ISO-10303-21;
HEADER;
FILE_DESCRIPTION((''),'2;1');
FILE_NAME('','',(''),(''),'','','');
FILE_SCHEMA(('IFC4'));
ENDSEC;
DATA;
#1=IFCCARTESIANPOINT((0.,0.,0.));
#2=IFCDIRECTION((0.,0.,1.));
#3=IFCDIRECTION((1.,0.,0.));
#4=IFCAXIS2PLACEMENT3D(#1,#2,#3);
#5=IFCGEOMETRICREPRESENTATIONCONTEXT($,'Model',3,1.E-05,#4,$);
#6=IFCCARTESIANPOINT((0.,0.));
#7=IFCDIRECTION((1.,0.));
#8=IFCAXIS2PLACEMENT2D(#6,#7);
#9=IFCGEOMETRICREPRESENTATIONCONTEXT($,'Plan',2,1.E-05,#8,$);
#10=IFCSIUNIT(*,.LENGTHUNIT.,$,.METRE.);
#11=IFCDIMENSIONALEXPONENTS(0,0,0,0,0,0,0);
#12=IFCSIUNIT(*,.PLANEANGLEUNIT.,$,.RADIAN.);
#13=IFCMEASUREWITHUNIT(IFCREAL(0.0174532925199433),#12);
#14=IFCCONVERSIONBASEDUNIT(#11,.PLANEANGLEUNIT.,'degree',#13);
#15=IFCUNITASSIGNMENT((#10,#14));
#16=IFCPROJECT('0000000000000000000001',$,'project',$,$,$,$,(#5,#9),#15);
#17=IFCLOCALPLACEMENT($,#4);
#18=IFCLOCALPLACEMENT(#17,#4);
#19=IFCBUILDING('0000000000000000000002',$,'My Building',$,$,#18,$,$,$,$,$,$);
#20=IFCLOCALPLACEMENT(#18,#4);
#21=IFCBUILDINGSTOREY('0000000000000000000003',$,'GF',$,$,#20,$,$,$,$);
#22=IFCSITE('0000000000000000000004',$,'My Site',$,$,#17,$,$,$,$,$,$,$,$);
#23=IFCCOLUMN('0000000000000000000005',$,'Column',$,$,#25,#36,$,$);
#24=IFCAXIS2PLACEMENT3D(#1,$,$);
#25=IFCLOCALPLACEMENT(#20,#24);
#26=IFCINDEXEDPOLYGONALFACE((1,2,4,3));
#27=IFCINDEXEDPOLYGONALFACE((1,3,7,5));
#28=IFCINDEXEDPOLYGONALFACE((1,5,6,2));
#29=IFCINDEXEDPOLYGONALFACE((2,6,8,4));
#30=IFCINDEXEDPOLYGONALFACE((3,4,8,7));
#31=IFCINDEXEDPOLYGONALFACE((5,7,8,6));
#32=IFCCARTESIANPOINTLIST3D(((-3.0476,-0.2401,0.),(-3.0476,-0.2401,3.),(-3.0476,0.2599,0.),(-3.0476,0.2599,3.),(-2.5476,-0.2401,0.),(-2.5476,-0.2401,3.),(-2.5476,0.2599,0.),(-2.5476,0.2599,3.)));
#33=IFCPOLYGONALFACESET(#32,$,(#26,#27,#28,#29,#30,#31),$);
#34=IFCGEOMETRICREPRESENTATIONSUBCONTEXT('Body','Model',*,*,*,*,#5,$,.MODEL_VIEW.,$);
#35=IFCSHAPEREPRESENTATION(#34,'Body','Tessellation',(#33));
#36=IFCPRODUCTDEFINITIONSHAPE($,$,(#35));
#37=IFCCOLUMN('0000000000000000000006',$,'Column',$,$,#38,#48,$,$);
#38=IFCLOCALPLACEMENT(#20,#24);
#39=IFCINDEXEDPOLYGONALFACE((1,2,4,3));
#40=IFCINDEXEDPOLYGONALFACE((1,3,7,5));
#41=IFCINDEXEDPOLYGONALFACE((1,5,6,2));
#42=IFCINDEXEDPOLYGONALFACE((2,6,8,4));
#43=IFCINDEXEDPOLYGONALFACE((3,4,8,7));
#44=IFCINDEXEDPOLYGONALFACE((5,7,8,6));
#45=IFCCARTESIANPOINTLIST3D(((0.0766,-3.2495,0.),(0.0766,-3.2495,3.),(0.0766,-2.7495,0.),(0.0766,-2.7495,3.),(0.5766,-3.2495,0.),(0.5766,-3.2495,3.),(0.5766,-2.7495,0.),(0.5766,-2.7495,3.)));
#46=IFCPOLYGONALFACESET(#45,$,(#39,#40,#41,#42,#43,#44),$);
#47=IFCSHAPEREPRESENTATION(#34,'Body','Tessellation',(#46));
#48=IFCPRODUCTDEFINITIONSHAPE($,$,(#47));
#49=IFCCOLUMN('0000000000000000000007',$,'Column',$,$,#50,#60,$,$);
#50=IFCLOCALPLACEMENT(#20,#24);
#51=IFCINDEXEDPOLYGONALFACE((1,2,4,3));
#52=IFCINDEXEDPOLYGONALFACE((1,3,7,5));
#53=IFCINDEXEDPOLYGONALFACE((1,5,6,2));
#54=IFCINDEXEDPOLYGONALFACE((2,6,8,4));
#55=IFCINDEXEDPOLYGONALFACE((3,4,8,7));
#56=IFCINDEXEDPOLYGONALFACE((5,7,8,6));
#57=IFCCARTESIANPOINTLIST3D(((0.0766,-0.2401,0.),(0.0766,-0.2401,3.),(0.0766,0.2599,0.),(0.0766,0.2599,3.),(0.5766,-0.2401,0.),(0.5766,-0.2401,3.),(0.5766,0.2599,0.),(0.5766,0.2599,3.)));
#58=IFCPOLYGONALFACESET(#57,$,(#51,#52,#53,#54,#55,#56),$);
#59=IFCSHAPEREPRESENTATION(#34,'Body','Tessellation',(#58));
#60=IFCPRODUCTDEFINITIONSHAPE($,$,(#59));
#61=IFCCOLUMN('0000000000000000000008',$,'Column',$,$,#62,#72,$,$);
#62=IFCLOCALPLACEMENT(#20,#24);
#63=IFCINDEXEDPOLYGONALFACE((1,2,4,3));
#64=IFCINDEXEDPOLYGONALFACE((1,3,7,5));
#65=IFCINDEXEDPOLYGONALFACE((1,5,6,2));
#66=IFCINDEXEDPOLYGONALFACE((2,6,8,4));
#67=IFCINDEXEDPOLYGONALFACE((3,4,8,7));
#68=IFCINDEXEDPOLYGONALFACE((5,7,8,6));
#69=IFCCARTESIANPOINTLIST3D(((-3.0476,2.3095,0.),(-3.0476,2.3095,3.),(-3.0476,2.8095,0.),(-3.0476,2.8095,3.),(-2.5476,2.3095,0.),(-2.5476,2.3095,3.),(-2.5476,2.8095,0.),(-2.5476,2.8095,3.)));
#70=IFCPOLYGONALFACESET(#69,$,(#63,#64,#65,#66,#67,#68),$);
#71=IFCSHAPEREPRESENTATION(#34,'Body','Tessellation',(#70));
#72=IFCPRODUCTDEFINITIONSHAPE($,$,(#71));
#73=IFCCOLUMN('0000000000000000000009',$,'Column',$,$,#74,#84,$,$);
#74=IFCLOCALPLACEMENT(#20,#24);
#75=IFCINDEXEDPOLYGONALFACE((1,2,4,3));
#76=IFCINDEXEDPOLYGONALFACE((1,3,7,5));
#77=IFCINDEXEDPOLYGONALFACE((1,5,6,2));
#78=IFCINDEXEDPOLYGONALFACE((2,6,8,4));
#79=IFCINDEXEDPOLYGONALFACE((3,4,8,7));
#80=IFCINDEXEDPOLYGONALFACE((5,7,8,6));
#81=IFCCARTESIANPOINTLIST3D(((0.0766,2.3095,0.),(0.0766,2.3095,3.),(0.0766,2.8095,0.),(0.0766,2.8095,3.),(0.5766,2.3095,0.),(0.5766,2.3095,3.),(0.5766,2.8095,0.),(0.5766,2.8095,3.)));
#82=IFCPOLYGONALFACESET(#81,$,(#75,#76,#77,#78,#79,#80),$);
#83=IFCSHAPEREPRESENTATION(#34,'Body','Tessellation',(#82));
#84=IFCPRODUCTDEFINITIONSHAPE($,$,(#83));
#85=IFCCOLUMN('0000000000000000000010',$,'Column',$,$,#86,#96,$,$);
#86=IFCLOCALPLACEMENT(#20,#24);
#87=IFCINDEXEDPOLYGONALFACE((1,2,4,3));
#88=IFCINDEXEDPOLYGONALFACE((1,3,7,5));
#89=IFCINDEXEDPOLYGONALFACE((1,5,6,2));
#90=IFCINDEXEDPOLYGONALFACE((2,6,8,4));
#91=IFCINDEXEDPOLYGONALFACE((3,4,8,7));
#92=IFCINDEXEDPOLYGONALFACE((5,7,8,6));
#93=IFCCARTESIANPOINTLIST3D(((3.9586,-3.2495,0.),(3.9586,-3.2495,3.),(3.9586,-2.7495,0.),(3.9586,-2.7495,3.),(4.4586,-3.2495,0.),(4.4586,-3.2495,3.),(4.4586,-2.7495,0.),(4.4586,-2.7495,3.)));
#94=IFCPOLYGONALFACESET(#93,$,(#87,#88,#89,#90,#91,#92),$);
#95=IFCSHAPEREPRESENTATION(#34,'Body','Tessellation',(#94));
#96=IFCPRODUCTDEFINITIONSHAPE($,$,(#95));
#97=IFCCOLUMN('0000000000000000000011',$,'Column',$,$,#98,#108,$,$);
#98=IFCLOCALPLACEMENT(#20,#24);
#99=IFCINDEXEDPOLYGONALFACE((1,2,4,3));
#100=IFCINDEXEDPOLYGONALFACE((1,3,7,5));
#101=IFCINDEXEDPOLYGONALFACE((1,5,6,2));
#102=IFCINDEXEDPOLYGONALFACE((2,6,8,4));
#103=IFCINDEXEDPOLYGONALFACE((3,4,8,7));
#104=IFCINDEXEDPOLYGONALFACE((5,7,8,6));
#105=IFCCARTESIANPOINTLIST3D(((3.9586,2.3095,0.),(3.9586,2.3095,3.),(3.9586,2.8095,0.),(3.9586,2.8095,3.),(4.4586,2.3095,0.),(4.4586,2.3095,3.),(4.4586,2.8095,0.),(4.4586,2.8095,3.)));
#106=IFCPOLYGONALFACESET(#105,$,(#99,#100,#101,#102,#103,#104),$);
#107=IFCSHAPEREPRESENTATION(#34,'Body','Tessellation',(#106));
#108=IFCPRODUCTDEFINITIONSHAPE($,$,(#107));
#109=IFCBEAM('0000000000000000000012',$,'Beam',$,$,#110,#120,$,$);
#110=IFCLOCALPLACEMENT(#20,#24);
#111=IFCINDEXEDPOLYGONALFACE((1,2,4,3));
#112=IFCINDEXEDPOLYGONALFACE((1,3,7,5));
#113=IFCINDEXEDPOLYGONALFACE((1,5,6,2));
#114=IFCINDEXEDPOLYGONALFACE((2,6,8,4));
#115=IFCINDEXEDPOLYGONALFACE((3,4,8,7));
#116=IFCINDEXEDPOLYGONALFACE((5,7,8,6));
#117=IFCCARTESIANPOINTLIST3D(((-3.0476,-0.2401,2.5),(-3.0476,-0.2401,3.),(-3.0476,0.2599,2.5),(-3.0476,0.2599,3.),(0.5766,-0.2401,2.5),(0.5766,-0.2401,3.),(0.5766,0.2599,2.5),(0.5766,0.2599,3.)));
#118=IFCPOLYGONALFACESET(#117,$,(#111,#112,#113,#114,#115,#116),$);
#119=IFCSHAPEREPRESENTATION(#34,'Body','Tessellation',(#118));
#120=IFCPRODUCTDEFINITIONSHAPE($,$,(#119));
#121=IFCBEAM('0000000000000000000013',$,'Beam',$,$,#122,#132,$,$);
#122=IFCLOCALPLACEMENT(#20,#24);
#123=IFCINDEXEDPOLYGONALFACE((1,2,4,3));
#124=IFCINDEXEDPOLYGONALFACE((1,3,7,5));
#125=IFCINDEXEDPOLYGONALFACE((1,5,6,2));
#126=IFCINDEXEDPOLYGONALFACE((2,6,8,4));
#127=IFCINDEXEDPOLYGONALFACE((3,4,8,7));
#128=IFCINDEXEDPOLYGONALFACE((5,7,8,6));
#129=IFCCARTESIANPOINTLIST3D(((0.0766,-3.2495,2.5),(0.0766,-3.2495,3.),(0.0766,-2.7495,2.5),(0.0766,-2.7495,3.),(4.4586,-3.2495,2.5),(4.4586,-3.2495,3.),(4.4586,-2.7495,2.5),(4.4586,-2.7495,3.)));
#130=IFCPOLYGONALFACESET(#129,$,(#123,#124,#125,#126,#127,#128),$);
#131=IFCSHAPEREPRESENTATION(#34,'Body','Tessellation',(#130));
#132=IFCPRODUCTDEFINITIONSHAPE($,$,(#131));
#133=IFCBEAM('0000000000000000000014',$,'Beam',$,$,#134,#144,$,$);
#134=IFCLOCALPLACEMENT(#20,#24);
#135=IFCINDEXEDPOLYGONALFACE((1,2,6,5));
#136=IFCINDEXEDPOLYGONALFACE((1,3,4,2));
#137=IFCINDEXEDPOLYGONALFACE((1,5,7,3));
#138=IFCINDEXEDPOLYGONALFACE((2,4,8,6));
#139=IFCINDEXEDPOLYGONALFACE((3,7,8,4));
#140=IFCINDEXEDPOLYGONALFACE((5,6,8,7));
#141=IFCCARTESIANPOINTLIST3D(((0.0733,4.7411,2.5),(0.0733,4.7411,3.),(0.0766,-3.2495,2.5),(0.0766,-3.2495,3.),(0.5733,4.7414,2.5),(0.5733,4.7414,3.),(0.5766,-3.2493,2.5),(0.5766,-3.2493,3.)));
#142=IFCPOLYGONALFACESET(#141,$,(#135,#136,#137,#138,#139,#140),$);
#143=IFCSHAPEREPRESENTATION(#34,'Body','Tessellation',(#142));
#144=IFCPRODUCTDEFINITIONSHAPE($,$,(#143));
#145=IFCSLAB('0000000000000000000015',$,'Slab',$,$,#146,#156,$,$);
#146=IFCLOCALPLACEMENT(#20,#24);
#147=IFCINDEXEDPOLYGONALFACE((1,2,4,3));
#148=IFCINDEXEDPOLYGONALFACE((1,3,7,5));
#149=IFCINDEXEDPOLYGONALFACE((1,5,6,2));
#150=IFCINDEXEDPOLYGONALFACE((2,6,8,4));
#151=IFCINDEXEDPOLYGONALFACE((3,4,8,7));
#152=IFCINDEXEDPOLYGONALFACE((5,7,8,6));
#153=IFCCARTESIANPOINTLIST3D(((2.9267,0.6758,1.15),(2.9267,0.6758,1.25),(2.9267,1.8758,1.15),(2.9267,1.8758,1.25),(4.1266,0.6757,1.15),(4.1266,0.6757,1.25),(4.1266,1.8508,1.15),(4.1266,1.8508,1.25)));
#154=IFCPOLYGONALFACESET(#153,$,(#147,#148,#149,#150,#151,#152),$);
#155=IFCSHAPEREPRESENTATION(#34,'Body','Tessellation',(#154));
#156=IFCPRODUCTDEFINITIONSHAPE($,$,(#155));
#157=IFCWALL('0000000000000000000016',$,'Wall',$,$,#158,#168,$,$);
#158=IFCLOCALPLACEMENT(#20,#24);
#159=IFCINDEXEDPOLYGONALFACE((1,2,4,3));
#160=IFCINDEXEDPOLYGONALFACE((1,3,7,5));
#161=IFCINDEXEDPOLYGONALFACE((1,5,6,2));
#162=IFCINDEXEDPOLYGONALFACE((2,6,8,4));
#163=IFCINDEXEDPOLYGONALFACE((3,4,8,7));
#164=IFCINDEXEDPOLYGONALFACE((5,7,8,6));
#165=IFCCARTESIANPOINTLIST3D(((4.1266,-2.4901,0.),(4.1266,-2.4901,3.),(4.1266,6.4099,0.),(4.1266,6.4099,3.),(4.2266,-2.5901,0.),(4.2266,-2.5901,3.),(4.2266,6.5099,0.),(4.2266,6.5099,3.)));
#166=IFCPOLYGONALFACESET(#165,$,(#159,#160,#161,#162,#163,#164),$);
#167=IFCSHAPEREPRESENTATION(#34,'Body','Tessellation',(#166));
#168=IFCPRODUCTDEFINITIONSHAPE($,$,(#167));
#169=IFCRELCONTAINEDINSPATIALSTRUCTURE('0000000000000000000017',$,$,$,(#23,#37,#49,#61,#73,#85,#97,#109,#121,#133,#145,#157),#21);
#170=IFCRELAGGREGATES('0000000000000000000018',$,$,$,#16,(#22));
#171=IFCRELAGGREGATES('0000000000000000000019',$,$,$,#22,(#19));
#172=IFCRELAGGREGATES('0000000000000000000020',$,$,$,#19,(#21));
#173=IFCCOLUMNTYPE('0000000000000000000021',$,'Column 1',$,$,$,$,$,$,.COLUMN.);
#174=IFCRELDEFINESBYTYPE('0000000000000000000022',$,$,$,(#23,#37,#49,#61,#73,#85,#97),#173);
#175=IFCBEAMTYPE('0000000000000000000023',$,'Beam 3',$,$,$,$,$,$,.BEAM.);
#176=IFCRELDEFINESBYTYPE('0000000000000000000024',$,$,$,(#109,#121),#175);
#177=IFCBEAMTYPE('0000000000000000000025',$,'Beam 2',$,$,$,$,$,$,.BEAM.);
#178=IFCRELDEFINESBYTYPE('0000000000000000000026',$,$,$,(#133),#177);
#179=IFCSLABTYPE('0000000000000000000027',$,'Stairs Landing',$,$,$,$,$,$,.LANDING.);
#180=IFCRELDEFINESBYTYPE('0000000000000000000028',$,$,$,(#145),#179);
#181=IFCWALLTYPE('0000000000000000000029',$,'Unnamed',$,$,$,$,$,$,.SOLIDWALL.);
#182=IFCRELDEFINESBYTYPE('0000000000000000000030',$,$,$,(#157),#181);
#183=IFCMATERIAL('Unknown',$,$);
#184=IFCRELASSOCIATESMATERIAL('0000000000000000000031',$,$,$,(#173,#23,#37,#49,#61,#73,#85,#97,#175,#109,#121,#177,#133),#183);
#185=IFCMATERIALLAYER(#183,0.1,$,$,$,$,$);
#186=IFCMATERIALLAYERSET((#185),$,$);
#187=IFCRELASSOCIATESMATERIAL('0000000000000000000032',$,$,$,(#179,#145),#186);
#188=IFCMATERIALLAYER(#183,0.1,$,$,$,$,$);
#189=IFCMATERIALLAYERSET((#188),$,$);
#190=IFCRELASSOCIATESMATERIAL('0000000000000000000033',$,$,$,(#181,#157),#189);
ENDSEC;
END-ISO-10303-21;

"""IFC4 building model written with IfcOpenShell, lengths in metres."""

from ifc_helpers import new_model, entity, si_unit, converted_unit, frame, origin_with_axes, origin_2d_with_axis, place, context, subcontext, project, spatial, line, indexed_curve, outline, extrude, material, layer, layer_set, layer_usage, material_profile, profile_set, profile_usage, type_object, element, save


model = new_model("IFC4")

# Units and contexts
model_context = context("Model", 3, precision=1e-05, world=origin_with_axes())
plan_context = context("Plan", 2, precision=1e-05, world=origin_2d_with_axis())
body_context_1 = subcontext(model_context, "Body", "Model", "MODEL_VIEW")
ifc_project = project(units=[si_unit("LENGTHUNIT", "METRE"), converted_unit("PLANEANGLEUNIT", "degree", entity("IfcReal", 0.0174532925199433), si_unit("PLANEANGLEUNIT", "RADIAN"), dimensions=[0, 0, 0, 0, 0, 0, 0])], contexts=[model_context, plan_context])

# Site, building, storey
site_placement = place(None, origin_with_axes())
site = spatial("IfcSite", under=ifc_project, at=site_placement, Name="My Site")
building_placement = place(site_placement, origin_with_axes())
building = spatial("IfcBuilding", under=site, at=building_placement, Name="My Building")
storey_placement = place(building_placement, origin_with_axes())
storey = spatial("IfcBuildingStorey", under=building, at=storey_placement, Name="GF")

# Columns
ifc_material_1 = material(Name="Unknown")
ifc_material_profile_1 = material_profile(ifc_material_1, outline(indexed_curve([(-0.25, -0.25), (0.25, -0.25), (0.25, 0.25), (-0.25, 0.25), (-0.25, -0.25)])))
ifc_profile_set_1 = profile_set([ifc_material_profile_1])
ifc_profile_usage_1 = profile_usage(ifc_profile_set_1, cardinal=5)
column_type = type_object("IfcColumnType", Name="Column 1", PredefinedType="COLUMN", material=ifc_profile_set_1)
column_1_placement = place(storey_placement, frame((-2.7976, 0.0099, 0.0), z_axis=(0.0, 0.0, 1.0), x_axis=(1.0, 0.0, 0.0)))
element("IfcColumn", 1, at=column_1_placement, inside=storey, type_object=column_type, material=ifc_profile_usage_1, Name="Column", context=body_context_1, shape_type="SweptSolid", body=[
    extrude(outline(indexed_curve([(-0.25, -0.25), (0.25, -0.25), (0.25, 0.25), (-0.25, 0.25), (-0.25, -0.25)])), origin_with_axes(), (0.0, 0.0, 1.0), 3.0),
])
ifc_profile_usage_2 = profile_usage(ifc_profile_set_1, cardinal=5)
column_2_placement = place(storey_placement, frame((0.3266, -2.9995, 0.0), z_axis=(0.0, 0.0, 1.0), x_axis=(1.0, 0.0, 0.0)))
element("IfcColumn", 2, at=column_2_placement, inside=storey, type_object=column_type, material=ifc_profile_usage_2, Name="Column", context=body_context_1, shape_type="SweptSolid", body=[
    extrude(outline(indexed_curve([(-0.25, -0.25), (0.25, -0.25), (0.25, 0.25), (-0.25, 0.25), (-0.25, -0.25)])), origin_with_axes(), (0.0, 0.0, 1.0), 3.0),
])
ifc_profile_usage_3 = profile_usage(ifc_profile_set_1, cardinal=5)
column_3_placement = place(storey_placement, frame((0.3266, 0.0099, 0.0), z_axis=(0.0, 0.0, 1.0), x_axis=(1.0, 0.0, 0.0)))
element("IfcColumn", 3, at=column_3_placement, inside=storey, type_object=column_type, material=ifc_profile_usage_3, Name="Column", context=body_context_1, shape_type="SweptSolid", body=[
    extrude(outline(indexed_curve([(-0.25, -0.25), (0.25, -0.25), (0.25, 0.25), (-0.25, 0.25), (-0.25, -0.25)])), origin_with_axes(), (0.0, 0.0, 1.0), 3.0),
])
ifc_profile_usage_4 = profile_usage(ifc_profile_set_1, cardinal=5)
column_4_placement = place(storey_placement, frame((-2.7976, 2.5595, 0.0), z_axis=(0.0, 0.0, 1.0), x_axis=(1.0, 0.0, 0.0)))
element("IfcColumn", 4, at=column_4_placement, inside=storey, type_object=column_type, material=ifc_profile_usage_4, Name="Column", context=body_context_1, shape_type="SweptSolid", body=[
    extrude(outline(indexed_curve([(-0.25, -0.25), (0.25, -0.25), (0.25, 0.25), (-0.25, 0.25), (-0.25, -0.25)])), origin_with_axes(), (0.0, 0.0, 1.0), 3.0),
])
ifc_profile_usage_5 = profile_usage(ifc_profile_set_1, cardinal=5)
column_5_placement = place(storey_placement, frame((0.3266, 2.5595, 0.0), z_axis=(0.0, 0.0, 1.0), x_axis=(1.0, 0.0, 0.0)))
element("IfcColumn", 5, at=column_5_placement, inside=storey, type_object=column_type, material=ifc_profile_usage_5, Name="Column", context=body_context_1, shape_type="SweptSolid", body=[
    extrude(outline(indexed_curve([(-0.25, -0.25), (0.25, -0.25), (0.25, 0.25), (-0.25, 0.25), (-0.25, -0.25)])), origin_with_axes(), (0.0, 0.0, 1.0), 3.0),
])
ifc_profile_usage_6 = profile_usage(ifc_profile_set_1, cardinal=5)
column_6_placement = place(storey_placement, frame((4.2086, -2.9995, 0.0), z_axis=(0.0, 0.0, 1.0), x_axis=(1.0, 0.0, 0.0)))
element("IfcColumn", 6, at=column_6_placement, inside=storey, type_object=column_type, material=ifc_profile_usage_6, Name="Column", context=body_context_1, shape_type="SweptSolid", body=[
    extrude(outline(indexed_curve([(-0.25, -0.25), (0.25, -0.25), (0.25, 0.25), (-0.25, 0.25), (-0.25, -0.25)])), origin_with_axes(), (0.0, 0.0, 1.0), 3.0),
])
ifc_profile_usage_7 = profile_usage(ifc_profile_set_1, cardinal=5)
column_7_placement = place(storey_placement, frame((4.2086, 2.5595, 0.0), z_axis=(0.0, 0.0, 1.0), x_axis=(1.0, 0.0, 0.0)))
element("IfcColumn", 7, at=column_7_placement, inside=storey, type_object=column_type, material=ifc_profile_usage_7, Name="Column", context=body_context_1, shape_type="SweptSolid", body=[
    extrude(outline(indexed_curve([(-0.25, -0.25), (0.25, -0.25), (0.25, 0.25), (-0.25, 0.25), (-0.25, -0.25)])), origin_with_axes(), (0.0, 0.0, 1.0), 3.0),
])

# Beams
ifc_material_profile_2 = material_profile(ifc_material_1, outline(indexed_curve([(-0.25, -0.25), (0.25, -0.25), (0.25, 0.25), (-0.25, 0.25), (-0.25, -0.25)])))
ifc_profile_set_2 = profile_set([ifc_material_profile_2])
ifc_profile_usage_8 = profile_usage(ifc_profile_set_2, cardinal=7)
beam_type_1 = type_object("IfcBeamType", Name="Beam 3", PredefinedType="BEAM", material=ifc_profile_set_2)
beam_1_placement = place(storey_placement, frame((0.5766, -0.2401, 3.0), z_axis=(-1.0, 0.0, 0.0), x_axis=(0.0, -1.0, 0.0)))
element("IfcBeam", 8, at=beam_1_placement, inside=storey, type_object=beam_type_1, material=ifc_profile_usage_8, Name="Beam", context=body_context_1, shape_type="SweptSolid", body=[
    extrude(outline(indexed_curve([(-0.25, -0.25), (0.25, -0.25), (0.25, 0.25), (-0.25, 0.25), (-0.25, -0.25)])), frame((-0.25, -0.25, 0.0), z_axis=(0.0, 0.0, 1.0), x_axis=(1.0, 0.0, 0.0)), (0.0, 0.0, 1.0), 3.6242),
])
ifc_profile_usage_9 = profile_usage(ifc_profile_set_2, cardinal=7)
beam_2_placement = place(storey_placement, frame((4.4586, -3.2495, 3.0), z_axis=(-1.0, 0.0, 0.0), x_axis=(0.0, -1.0, 0.0)))
element("IfcBeam", 9, at=beam_2_placement, inside=storey, type_object=beam_type_1, material=ifc_profile_usage_9, Name="Beam", context=body_context_1, shape_type="SweptSolid", body=[
    extrude(outline(indexed_curve([(-0.25, -0.25), (0.25, -0.25), (0.25, 0.25), (-0.25, 0.25), (-0.25, -0.25)])), frame((-0.25, -0.25, 0.0), z_axis=(0.0, 0.0, 1.0), x_axis=(1.0, 0.0, 0.0)), (0.0, 0.0, 1.0), 4.382),
])
ifc_material_profile_3 = material_profile(ifc_material_1, outline(indexed_curve([(-0.25, -0.25), (0.25, -0.25), (0.25, 0.25), (-0.25, 0.25), (-0.25, -0.25)])))
ifc_profile_set_3 = profile_set([ifc_material_profile_3])
ifc_profile_usage_10 = profile_usage(ifc_profile_set_3, cardinal=7)
beam_type_2 = type_object("IfcBeamType", Name="Beam 2", PredefinedType="BEAM", material=ifc_profile_set_3)
beam_3_placement = place(storey_placement, frame((0.0766, -3.2495, 3.0), z_axis=(-0.000418, 1.0, 0.0), x_axis=(-1.0, -0.000418, 0.0)))
element("IfcBeam", 10, at=beam_3_placement, inside=storey, type_object=beam_type_2, material=ifc_profile_usage_10, Name="Beam", context=body_context_1, shape_type="SweptSolid", body=[
    extrude(outline(indexed_curve([(-0.25, -0.25), (0.25, -0.25), (0.25, 0.25), (-0.25, 0.25), (-0.25, -0.25)])), frame((-0.25, -0.25, 0.0), z_axis=(0.0, 0.0, 1.0), x_axis=(1.0, 0.0, 0.0)), (0.0, 0.0, 1.0), 7.9907),
])

# Slab
ifc_layer_1 = layer(ifc_material_1, 0.1)
ifc_layer_set_1 = layer_set([ifc_layer_1])
ifc_layer_usage_1 = layer_usage(ifc_layer_set_1, "AXIS3", "POSITIVE", -0.1)
slab_type = type_object("IfcSlabType", Name="Stairs Landing", PredefinedType="LANDING", material=ifc_layer_set_1)
slab_placement = place(storey_placement, frame((4.1267, 0.6758, 1.25), z_axis=(0.0, 0.0, 1.0), x_axis=(1.0, 0.0, 0.0)))
element("IfcSlab", 11, at=slab_placement, inside=storey, type_object=slab_type, material=ifc_layer_usage_1, Name="Slab", context=body_context_1, shape_type="SweptSolid", body=[
    extrude(outline(indexed_curve([(-0.0001, -0.0001), (-0.0001, 1.175), (-1.2, 1.2), (-1.2, 0.0), (-0.0001, -0.0001)])), frame((0.0, 0.0, -0.1), z_axis=(0.0, 0.0, 1.0), x_axis=(1.0, 0.0, 0.0)), (0.0, 0.0, 1.0), 0.1),
])

# Shared definitions
ifc_layer_2 = layer(ifc_material_1, 0.1)
ifc_layer_set_2 = layer_set([ifc_layer_2])
wall_type = type_object("IfcWallType", Name="Unnamed", PredefinedType="SOLIDWALL", material=ifc_layer_set_2)

# Wall
ifc_layer_usage_2 = layer_usage(ifc_layer_set_2, "AXIS2", "POSITIVE", 0.0)
wall_1_placement = place(storey_placement, frame((4.2266, -2.5901, 0.0), z_axis=(0.0, 0.0, 1.0), x_axis=(0.0, 1.0, 0.0)))
element("IfcWall", 12, at=wall_1_placement, inside=storey, type_object=wall_type, material=ifc_layer_usage_2, Name="Wall", context=body_context_1, shape_type="SweptSolid", body=[
    extrude(outline(indexed_curve([(0.0, 0.0), (0.1, 0.1), (9.0, 0.1), (9.1, 0.0)], segments=[line(1, 2, 3, 4, 1)])), origin_with_axes(), (0.0, 0.0, 1.0), 3.0),
])

save(model, "model.ifc")
